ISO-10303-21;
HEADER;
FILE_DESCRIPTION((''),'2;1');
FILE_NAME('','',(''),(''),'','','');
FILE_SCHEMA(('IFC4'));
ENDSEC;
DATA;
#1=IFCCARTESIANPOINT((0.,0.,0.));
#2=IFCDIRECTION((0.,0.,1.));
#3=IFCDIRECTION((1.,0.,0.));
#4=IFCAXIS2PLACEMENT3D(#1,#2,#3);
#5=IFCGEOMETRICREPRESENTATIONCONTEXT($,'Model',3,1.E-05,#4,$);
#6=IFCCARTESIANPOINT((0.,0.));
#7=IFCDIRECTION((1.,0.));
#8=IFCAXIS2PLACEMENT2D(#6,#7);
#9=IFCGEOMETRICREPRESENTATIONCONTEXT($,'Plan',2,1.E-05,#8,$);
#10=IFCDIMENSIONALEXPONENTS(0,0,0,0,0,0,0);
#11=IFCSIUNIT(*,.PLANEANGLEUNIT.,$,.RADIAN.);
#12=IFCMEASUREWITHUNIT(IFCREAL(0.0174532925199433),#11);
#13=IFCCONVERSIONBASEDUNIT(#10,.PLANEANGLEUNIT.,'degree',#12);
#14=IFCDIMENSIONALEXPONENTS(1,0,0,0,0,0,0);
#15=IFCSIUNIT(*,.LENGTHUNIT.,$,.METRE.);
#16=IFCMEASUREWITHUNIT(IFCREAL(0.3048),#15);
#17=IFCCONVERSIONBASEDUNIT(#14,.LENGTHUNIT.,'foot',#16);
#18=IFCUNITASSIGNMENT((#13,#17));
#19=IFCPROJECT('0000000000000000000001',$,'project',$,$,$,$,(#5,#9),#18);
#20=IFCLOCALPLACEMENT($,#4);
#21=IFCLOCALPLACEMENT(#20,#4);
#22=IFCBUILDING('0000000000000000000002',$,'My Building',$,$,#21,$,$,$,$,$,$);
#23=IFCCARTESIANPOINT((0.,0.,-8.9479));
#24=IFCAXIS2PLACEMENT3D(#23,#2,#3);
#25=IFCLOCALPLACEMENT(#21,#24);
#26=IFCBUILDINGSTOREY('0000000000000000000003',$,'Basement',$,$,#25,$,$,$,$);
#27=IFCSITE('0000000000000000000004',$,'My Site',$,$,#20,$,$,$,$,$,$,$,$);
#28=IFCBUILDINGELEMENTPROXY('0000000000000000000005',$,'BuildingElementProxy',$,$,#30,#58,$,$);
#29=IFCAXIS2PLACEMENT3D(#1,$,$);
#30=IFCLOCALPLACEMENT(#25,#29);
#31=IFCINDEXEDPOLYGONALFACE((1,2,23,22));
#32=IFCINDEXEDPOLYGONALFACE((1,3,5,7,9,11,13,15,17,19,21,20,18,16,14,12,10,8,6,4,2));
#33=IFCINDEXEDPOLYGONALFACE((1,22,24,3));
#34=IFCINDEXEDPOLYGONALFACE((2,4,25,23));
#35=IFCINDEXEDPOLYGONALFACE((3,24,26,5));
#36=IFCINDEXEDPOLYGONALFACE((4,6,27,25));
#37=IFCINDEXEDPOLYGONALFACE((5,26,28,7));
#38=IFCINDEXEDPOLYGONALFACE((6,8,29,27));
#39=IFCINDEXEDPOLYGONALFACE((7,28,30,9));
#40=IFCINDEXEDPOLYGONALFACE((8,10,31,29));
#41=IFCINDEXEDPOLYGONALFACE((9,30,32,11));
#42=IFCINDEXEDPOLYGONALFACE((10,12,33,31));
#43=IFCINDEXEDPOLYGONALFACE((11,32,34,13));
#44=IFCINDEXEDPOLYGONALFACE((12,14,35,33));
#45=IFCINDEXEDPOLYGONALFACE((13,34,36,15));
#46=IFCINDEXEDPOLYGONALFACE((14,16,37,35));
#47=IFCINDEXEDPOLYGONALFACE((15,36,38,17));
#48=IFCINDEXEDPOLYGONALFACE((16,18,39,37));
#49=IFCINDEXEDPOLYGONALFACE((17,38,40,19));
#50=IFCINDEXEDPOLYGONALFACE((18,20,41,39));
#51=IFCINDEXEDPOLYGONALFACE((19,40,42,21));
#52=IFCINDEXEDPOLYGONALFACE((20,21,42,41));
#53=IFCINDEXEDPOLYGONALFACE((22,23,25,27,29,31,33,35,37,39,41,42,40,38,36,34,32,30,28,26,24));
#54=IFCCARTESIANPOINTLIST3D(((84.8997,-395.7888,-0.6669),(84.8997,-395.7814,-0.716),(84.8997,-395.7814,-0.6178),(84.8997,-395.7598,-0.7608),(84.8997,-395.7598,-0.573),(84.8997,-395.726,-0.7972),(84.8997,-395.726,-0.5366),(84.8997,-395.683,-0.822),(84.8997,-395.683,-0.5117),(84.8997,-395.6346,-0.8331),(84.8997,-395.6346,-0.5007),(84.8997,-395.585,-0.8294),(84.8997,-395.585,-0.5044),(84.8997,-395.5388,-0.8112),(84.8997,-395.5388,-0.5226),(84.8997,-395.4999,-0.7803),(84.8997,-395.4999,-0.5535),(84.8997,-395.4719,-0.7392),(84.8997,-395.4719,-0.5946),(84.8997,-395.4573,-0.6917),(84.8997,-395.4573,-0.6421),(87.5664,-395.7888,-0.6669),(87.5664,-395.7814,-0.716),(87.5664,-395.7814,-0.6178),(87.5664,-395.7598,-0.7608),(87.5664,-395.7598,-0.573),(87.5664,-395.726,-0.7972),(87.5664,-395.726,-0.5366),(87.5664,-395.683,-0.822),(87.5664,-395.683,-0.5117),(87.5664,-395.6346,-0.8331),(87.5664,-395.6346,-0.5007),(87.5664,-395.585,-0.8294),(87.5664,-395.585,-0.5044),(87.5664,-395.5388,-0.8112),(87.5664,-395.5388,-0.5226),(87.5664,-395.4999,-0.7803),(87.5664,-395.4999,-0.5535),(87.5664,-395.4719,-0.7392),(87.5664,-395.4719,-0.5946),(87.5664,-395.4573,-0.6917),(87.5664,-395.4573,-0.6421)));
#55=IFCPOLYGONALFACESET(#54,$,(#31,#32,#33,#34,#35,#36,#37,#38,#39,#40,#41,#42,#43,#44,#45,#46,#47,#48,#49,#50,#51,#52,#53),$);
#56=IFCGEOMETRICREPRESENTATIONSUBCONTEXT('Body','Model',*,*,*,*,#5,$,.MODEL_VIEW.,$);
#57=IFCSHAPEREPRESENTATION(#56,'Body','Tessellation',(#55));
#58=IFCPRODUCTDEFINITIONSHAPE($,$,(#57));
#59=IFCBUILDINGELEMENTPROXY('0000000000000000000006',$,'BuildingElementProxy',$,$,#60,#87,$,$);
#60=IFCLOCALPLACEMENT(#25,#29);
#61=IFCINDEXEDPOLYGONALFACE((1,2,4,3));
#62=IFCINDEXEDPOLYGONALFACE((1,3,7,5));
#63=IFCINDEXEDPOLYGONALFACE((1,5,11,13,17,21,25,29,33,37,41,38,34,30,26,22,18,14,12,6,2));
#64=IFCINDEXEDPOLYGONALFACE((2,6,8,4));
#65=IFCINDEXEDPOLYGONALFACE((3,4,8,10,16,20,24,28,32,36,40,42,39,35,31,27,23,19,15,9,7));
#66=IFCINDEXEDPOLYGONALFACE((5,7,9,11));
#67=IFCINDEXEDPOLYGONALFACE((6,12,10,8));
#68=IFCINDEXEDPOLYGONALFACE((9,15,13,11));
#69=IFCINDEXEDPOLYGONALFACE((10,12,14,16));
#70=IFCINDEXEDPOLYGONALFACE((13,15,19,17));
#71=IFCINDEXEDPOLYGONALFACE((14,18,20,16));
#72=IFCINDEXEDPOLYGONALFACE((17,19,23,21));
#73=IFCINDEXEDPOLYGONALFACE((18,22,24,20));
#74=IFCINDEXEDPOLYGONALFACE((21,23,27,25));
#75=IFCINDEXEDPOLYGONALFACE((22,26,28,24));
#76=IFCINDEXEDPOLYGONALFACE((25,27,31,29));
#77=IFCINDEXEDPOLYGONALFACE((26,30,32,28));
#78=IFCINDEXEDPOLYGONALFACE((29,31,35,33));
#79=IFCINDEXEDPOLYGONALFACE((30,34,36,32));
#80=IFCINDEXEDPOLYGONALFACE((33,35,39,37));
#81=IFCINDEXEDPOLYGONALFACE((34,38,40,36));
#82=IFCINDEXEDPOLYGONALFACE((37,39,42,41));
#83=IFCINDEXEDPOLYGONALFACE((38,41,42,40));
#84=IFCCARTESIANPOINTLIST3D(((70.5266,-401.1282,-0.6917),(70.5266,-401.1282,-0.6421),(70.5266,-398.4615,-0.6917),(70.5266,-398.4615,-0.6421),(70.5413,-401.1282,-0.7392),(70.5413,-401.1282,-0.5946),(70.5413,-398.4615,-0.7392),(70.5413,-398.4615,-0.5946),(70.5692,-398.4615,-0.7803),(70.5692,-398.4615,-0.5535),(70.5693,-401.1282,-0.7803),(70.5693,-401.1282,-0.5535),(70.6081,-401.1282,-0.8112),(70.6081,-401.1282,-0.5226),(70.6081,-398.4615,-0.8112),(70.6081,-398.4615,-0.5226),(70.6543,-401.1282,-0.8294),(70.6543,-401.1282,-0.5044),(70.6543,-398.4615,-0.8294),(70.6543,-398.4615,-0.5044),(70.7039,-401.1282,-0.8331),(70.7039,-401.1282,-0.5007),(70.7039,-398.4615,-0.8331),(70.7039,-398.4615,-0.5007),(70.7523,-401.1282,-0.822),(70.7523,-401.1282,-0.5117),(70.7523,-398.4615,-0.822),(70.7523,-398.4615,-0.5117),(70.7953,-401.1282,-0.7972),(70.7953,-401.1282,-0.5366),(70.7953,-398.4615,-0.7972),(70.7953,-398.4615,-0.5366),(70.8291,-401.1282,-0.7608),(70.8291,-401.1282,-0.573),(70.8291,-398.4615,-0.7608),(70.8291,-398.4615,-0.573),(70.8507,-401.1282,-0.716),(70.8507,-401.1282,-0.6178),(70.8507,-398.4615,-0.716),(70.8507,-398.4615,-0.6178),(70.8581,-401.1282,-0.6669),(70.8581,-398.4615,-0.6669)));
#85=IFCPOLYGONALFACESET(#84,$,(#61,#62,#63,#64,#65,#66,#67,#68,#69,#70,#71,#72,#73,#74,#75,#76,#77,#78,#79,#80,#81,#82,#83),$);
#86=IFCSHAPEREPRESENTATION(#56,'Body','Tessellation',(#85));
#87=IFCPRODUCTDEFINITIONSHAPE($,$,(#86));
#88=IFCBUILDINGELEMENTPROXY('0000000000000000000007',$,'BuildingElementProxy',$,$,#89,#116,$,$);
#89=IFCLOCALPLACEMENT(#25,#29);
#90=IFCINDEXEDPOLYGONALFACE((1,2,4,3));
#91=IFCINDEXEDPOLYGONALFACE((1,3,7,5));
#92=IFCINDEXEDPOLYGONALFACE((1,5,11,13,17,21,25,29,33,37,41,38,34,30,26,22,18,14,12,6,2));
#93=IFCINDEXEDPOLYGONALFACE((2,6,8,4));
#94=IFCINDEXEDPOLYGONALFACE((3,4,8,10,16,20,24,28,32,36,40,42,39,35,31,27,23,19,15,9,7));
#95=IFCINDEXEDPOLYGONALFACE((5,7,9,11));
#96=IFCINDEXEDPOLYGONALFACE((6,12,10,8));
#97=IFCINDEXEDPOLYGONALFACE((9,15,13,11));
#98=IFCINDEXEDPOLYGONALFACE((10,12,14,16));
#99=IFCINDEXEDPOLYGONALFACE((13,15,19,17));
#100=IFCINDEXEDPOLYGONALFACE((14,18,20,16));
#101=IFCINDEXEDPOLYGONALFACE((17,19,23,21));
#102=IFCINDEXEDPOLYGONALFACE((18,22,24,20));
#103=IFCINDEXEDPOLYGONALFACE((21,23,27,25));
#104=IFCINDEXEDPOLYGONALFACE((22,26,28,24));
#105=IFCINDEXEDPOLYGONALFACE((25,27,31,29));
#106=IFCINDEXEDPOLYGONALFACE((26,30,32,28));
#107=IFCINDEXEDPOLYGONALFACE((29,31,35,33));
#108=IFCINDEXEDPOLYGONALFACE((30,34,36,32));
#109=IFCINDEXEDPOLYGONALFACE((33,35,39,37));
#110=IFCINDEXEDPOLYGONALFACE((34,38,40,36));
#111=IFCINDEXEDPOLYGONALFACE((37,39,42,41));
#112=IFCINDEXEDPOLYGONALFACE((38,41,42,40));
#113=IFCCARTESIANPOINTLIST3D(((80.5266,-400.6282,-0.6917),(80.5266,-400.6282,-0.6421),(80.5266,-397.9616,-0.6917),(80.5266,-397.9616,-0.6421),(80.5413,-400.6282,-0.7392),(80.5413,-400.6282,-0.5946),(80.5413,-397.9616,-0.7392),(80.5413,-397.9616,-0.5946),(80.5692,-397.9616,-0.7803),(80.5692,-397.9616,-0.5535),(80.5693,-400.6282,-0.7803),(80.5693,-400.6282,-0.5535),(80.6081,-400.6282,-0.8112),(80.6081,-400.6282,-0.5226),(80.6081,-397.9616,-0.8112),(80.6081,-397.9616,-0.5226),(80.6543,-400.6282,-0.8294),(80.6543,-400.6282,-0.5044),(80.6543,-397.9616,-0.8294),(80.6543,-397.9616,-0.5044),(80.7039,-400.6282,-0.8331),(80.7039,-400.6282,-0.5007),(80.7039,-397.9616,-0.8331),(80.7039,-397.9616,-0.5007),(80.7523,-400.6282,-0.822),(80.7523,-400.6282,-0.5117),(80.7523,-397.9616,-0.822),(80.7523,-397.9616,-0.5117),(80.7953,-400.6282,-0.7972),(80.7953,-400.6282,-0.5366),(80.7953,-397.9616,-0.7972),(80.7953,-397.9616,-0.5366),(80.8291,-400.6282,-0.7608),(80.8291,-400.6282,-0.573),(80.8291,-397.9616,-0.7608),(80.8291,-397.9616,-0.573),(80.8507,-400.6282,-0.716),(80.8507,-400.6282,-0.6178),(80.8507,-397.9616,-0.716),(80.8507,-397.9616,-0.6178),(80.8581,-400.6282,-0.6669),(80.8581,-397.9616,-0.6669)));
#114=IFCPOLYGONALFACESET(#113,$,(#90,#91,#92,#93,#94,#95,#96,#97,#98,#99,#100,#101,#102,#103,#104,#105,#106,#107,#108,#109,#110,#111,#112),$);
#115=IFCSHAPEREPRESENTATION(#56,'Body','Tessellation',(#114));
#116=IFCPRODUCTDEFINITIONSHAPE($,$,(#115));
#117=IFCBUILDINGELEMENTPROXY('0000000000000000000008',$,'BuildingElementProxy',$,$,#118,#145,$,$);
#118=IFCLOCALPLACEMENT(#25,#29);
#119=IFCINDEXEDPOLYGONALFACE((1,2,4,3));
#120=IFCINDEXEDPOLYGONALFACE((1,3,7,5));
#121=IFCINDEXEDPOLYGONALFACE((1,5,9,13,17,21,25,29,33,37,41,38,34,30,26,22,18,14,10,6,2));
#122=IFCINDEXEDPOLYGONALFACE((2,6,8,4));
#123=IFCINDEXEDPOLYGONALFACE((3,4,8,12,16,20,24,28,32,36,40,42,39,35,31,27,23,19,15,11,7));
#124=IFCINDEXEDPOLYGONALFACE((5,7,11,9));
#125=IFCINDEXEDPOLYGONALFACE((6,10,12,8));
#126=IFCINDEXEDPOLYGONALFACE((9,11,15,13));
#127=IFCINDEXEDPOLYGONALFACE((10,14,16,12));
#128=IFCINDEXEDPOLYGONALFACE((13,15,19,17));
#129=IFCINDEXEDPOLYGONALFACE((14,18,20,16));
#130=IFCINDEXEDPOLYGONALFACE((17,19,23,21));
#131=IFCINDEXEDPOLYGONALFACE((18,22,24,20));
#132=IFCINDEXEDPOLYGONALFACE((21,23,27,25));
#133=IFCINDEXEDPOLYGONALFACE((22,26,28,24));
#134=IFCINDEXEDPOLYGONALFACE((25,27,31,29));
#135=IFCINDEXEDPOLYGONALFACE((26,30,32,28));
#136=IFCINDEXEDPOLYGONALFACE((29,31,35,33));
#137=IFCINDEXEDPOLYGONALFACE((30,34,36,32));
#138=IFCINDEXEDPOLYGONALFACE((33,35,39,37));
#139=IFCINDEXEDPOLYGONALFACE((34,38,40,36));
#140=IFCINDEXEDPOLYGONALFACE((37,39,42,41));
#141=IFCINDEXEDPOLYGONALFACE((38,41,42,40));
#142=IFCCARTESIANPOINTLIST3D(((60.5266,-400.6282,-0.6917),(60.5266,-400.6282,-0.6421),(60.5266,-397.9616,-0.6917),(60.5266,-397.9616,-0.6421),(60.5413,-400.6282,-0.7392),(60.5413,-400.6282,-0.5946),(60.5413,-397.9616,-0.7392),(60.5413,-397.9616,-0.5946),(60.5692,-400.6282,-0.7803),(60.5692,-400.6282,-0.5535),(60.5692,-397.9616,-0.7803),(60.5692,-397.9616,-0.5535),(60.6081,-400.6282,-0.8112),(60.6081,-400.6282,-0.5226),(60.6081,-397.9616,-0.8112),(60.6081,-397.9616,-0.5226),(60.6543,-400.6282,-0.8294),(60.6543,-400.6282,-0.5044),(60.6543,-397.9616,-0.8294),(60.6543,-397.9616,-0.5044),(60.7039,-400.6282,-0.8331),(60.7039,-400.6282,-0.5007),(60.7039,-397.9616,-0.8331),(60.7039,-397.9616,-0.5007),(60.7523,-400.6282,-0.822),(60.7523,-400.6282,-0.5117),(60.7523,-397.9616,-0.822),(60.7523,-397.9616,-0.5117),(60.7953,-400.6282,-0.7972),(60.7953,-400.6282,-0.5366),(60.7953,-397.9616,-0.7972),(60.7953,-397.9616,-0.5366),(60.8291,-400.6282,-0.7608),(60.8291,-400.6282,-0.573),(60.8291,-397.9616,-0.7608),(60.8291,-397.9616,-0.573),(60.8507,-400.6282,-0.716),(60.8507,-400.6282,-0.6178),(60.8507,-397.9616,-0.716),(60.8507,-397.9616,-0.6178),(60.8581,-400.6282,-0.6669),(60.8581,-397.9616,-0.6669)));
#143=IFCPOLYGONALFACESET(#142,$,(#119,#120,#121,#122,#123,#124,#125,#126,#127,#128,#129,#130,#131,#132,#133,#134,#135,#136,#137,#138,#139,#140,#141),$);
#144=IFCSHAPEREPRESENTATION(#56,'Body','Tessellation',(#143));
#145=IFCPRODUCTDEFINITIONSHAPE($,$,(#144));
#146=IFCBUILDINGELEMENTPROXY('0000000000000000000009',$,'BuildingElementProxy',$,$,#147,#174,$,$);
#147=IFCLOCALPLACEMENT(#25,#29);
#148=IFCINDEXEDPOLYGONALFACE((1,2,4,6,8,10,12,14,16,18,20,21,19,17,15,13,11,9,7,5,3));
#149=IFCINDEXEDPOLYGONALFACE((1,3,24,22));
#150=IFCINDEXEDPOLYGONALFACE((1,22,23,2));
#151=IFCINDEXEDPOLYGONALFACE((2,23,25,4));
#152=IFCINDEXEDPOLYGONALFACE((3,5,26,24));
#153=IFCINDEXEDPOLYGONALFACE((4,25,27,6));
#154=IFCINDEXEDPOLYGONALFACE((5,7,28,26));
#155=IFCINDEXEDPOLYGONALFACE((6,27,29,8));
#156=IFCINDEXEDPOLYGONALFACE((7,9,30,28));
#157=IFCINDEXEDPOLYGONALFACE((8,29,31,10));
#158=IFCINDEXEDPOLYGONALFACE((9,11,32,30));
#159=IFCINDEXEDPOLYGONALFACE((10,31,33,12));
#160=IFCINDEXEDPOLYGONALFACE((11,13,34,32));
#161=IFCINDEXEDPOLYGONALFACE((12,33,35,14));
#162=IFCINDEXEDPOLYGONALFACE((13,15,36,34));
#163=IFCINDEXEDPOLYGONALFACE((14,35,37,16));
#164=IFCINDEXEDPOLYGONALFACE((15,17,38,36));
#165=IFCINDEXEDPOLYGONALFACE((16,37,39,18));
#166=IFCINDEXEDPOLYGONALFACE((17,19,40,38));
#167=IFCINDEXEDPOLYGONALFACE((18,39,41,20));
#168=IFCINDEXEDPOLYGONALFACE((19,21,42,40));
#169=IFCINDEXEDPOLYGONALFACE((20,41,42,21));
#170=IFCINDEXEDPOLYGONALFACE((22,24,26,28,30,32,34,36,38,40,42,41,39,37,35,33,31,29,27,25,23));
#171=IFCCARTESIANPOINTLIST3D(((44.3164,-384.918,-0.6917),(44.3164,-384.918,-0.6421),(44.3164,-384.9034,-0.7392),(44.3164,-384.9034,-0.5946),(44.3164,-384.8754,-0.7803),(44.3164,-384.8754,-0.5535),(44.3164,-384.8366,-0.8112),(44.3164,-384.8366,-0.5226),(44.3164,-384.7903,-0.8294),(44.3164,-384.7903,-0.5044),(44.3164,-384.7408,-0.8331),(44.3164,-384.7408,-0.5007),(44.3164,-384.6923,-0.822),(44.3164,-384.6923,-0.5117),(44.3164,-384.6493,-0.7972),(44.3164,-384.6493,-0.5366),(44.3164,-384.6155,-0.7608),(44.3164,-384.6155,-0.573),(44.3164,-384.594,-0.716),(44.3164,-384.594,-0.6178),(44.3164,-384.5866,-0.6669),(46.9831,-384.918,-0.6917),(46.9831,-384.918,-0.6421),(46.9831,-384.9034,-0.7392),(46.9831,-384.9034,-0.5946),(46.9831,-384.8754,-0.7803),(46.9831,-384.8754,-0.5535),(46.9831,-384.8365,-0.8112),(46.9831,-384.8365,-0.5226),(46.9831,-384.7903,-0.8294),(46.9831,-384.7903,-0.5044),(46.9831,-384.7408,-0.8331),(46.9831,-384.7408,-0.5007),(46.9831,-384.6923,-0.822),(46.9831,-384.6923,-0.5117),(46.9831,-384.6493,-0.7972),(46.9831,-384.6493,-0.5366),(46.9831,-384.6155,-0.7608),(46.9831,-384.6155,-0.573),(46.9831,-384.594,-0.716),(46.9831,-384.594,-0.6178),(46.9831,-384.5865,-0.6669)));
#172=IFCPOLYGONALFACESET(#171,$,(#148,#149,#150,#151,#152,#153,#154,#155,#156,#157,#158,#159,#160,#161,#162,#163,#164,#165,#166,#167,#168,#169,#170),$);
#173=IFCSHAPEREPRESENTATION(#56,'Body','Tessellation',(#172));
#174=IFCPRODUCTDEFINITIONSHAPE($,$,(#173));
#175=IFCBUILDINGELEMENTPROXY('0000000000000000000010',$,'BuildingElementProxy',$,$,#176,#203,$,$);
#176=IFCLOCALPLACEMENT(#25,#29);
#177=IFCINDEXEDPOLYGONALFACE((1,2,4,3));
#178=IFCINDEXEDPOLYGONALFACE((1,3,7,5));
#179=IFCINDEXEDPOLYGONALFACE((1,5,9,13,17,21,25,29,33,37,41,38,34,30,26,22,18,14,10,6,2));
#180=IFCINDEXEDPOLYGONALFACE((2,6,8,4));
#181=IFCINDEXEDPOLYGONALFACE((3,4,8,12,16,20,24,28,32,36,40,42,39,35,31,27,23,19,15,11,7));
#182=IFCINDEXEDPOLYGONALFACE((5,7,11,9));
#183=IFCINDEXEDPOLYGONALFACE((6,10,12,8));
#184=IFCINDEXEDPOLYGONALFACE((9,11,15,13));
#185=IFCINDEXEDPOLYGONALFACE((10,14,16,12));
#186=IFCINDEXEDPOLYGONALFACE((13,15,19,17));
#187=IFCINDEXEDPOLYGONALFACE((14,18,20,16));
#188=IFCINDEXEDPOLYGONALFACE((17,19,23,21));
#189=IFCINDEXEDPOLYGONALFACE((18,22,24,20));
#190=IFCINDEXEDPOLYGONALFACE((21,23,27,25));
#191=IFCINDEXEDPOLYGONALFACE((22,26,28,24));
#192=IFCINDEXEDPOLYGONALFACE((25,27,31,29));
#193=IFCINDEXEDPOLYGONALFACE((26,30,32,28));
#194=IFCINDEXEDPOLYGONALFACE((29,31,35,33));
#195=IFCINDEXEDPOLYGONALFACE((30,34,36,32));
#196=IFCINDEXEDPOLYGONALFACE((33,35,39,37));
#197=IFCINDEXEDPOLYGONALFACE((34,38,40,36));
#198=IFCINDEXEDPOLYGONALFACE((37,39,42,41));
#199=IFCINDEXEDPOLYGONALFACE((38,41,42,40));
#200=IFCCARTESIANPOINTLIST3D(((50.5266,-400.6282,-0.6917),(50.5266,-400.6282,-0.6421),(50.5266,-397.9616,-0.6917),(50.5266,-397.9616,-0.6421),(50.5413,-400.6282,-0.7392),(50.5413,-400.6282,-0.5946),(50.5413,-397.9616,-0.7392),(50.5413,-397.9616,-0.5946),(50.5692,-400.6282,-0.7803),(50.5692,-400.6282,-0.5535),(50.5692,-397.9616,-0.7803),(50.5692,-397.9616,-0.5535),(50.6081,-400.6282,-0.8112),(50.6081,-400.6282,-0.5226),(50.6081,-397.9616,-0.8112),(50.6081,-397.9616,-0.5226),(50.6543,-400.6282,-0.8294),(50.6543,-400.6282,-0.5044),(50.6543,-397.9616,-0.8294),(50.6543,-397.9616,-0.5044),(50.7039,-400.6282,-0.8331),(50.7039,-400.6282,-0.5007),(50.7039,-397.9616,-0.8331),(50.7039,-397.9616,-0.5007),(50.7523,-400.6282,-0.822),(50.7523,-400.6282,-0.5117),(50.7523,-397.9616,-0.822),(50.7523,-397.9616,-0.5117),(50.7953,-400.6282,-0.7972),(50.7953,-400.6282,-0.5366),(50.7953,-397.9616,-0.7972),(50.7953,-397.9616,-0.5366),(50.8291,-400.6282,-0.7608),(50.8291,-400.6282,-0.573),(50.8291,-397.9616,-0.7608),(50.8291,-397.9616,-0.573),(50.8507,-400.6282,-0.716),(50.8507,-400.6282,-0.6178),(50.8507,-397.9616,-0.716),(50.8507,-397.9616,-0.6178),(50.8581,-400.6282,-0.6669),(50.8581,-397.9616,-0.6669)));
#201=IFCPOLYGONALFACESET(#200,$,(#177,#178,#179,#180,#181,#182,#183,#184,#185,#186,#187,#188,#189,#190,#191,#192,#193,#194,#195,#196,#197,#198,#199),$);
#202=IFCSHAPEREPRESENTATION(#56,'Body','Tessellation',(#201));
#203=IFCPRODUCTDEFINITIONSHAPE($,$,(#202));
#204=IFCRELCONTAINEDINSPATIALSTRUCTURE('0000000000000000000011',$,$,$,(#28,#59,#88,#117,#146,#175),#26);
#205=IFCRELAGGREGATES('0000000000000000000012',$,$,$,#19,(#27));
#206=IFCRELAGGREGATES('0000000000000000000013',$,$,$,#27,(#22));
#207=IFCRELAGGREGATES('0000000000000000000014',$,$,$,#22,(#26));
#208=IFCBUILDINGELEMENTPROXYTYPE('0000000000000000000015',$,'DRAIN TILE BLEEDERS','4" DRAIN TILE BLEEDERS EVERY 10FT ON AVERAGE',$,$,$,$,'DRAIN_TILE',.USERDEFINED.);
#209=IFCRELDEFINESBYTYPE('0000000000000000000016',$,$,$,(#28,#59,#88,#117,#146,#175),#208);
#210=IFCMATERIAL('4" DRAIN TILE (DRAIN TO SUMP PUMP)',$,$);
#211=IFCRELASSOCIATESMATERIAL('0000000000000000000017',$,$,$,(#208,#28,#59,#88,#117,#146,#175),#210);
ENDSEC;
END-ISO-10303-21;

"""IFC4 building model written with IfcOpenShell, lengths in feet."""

from ifc_helpers import new_model, entity, si_unit, converted_unit, frame, origin_with_axes, origin_2d_with_axis, place, context, subcontext, project, spatial, circle, extrude, material, material_profile, profile_set, profile_usage, type_object, element, save


model = new_model("IFC4")

# Units and contexts
model_context = context("Model", 3, precision=1e-05, world=origin_with_axes())
plan_context = context("Plan", 2, precision=1e-05, world=origin_2d_with_axis())
body_context = subcontext(model_context, "Body", "Model", "MODEL_VIEW")
ifc_project = project(units=[converted_unit("PLANEANGLEUNIT", "degree", entity("IfcReal", 0.0174532925199433), si_unit("PLANEANGLEUNIT", "RADIAN"), dimensions=[0, 0, 0, 0, 0, 0, 0]), converted_unit("LENGTHUNIT", "foot", entity("IfcReal", 0.3048), si_unit("LENGTHUNIT", "METRE"), dimensions=[1, 0, 0, 0, 0, 0, 0])], contexts=[model_context, plan_context])

# Site, building, storey
site_placement = place(None, origin_with_axes())
site = spatial("IfcSite", under=ifc_project, at=site_placement, Name="My Site")
building_placement = place(site_placement, origin_with_axes())
building = spatial("IfcBuilding", under=site, at=building_placement, Name="My Building")
storey_placement = place(building_placement, frame((0.0, 0.0, -8.9479), z_axis=(0.0, 0.0, 1.0), x_axis=(1.0, 0.0, 0.0)))
storey = spatial("IfcBuildingStorey", under=building, at=storey_placement, Name="Basement")

# Building element proxies
ifc_material_1 = material(Name="4\" DRAIN TILE (DRAIN TO SUMP PUMP)")
ifc_material_profile_1 = material_profile(ifc_material_1, circle(Radius=0.1667, kind="CURVE"))
ifc_profile_set_1 = profile_set([ifc_material_profile_1])
building_element_proxy_type_1 = type_object("IfcBuildingElementProxyType", Name="DRAIN TILE BLEEDERS", Description="4\" DRAIN TILE BLEEDERS EVERY 10FT ON AVERAGE", ElementType="DRAIN_TILE", PredefinedType="USERDEFINED", material=ifc_profile_set_1)
ifc_profile_usage_1 = profile_usage(ifc_profile_set_1)
proxy_1_placement = place(storey_placement, frame((87.5664, -395.6221, -0.6669), z_axis=(-1.0, -0.000002, 0.0), x_axis=(0.000002, -1.0, 0.0)))
element("IfcBuildingElementProxy", 1, at=proxy_1_placement, inside=storey, type_object=building_element_proxy_type_1, material=ifc_profile_usage_1, Name="BuildingElementProxy", context=body_context, shape_type="SweptSolid", body=[
    extrude(circle(Radius=0.1667, kind="CURVE"), origin_with_axes(), (0.0, 0.0, 1.0), 2.6667),
])
ifc_profile_usage_2 = profile_usage(ifc_profile_set_1)
proxy_2_placement = place(storey_placement, frame((70.6914, -398.4615, -0.6669), z_axis=(0.000002, -1.0, 0.0), x_axis=(1.0, 0.000002, 0.0)))
element("IfcBuildingElementProxy", 2, at=proxy_2_placement, inside=storey, type_object=building_element_proxy_type_1, material=ifc_profile_usage_2, Name="BuildingElementProxy", context=body_context, shape_type="SweptSolid", body=[
    extrude(circle(Radius=0.1667, kind="CURVE"), origin_with_axes(), (0.0, 0.0, 1.0), 2.6667),
])
ifc_profile_usage_3 = profile_usage(ifc_profile_set_1)
proxy_3_placement = place(storey_placement, frame((80.6914, -397.9616, -0.6669), z_axis=(0.000002, -1.0, 0.0), x_axis=(1.0, 0.000002, 0.0)))
element("IfcBuildingElementProxy", 3, at=proxy_3_placement, inside=storey, type_object=building_element_proxy_type_1, material=ifc_profile_usage_3, Name="BuildingElementProxy", context=body_context, shape_type="SweptSolid", body=[
    extrude(circle(Radius=0.1667, kind="CURVE"), origin_with_axes(), (0.0, 0.0, 1.0), 2.6667),
])
ifc_profile_usage_4 = profile_usage(ifc_profile_set_1)
proxy_4_placement = place(storey_placement, frame((60.6914, -397.9616, -0.6669), z_axis=(0.000002, -1.0, 0.0), x_axis=(1.0, 0.000002, 0.0)))
element("IfcBuildingElementProxy", 4, at=proxy_4_placement, inside=storey, type_object=building_element_proxy_type_1, material=ifc_profile_usage_4, Name="BuildingElementProxy", context=body_context, shape_type="SweptSolid", body=[
    extrude(circle(Radius=0.1667, kind="CURVE"), origin_with_axes(), (0.0, 0.0, 1.0), 2.6667),
])
ifc_profile_usage_5 = profile_usage(ifc_profile_set_1)
proxy_5_placement = place(storey_placement, frame((44.3164, -384.7532, -0.6669), z_axis=(1.0, 0.000002, 0.0), x_axis=(-0.000002, 1.0, 0.0)))
element("IfcBuildingElementProxy", 5, at=proxy_5_placement, inside=storey, type_object=building_element_proxy_type_1, material=ifc_profile_usage_5, Name="BuildingElementProxy", context=body_context, shape_type="SweptSolid", body=[
    extrude(circle(Radius=0.1667, kind="CURVE"), origin_with_axes(), (0.0, 0.0, 1.0), 2.6667),
])
ifc_profile_usage_6 = profile_usage(ifc_profile_set_1)
proxy_6_placement = place(storey_placement, frame((50.6914, -397.9616, -0.6669), z_axis=(0.000002, -1.0, 0.0), x_axis=(1.0, 0.000002, 0.0)))
element("IfcBuildingElementProxy", 6, at=proxy_6_placement, inside=storey, type_object=building_element_proxy_type_1, material=ifc_profile_usage_6, Name="BuildingElementProxy", context=body_context, shape_type="SweptSolid", body=[
    extrude(circle(Radius=0.1667, kind="CURVE"), origin_with_axes(), (0.0, 0.0, 1.0), 2.6667),
])

save(model, "model.ifc")
